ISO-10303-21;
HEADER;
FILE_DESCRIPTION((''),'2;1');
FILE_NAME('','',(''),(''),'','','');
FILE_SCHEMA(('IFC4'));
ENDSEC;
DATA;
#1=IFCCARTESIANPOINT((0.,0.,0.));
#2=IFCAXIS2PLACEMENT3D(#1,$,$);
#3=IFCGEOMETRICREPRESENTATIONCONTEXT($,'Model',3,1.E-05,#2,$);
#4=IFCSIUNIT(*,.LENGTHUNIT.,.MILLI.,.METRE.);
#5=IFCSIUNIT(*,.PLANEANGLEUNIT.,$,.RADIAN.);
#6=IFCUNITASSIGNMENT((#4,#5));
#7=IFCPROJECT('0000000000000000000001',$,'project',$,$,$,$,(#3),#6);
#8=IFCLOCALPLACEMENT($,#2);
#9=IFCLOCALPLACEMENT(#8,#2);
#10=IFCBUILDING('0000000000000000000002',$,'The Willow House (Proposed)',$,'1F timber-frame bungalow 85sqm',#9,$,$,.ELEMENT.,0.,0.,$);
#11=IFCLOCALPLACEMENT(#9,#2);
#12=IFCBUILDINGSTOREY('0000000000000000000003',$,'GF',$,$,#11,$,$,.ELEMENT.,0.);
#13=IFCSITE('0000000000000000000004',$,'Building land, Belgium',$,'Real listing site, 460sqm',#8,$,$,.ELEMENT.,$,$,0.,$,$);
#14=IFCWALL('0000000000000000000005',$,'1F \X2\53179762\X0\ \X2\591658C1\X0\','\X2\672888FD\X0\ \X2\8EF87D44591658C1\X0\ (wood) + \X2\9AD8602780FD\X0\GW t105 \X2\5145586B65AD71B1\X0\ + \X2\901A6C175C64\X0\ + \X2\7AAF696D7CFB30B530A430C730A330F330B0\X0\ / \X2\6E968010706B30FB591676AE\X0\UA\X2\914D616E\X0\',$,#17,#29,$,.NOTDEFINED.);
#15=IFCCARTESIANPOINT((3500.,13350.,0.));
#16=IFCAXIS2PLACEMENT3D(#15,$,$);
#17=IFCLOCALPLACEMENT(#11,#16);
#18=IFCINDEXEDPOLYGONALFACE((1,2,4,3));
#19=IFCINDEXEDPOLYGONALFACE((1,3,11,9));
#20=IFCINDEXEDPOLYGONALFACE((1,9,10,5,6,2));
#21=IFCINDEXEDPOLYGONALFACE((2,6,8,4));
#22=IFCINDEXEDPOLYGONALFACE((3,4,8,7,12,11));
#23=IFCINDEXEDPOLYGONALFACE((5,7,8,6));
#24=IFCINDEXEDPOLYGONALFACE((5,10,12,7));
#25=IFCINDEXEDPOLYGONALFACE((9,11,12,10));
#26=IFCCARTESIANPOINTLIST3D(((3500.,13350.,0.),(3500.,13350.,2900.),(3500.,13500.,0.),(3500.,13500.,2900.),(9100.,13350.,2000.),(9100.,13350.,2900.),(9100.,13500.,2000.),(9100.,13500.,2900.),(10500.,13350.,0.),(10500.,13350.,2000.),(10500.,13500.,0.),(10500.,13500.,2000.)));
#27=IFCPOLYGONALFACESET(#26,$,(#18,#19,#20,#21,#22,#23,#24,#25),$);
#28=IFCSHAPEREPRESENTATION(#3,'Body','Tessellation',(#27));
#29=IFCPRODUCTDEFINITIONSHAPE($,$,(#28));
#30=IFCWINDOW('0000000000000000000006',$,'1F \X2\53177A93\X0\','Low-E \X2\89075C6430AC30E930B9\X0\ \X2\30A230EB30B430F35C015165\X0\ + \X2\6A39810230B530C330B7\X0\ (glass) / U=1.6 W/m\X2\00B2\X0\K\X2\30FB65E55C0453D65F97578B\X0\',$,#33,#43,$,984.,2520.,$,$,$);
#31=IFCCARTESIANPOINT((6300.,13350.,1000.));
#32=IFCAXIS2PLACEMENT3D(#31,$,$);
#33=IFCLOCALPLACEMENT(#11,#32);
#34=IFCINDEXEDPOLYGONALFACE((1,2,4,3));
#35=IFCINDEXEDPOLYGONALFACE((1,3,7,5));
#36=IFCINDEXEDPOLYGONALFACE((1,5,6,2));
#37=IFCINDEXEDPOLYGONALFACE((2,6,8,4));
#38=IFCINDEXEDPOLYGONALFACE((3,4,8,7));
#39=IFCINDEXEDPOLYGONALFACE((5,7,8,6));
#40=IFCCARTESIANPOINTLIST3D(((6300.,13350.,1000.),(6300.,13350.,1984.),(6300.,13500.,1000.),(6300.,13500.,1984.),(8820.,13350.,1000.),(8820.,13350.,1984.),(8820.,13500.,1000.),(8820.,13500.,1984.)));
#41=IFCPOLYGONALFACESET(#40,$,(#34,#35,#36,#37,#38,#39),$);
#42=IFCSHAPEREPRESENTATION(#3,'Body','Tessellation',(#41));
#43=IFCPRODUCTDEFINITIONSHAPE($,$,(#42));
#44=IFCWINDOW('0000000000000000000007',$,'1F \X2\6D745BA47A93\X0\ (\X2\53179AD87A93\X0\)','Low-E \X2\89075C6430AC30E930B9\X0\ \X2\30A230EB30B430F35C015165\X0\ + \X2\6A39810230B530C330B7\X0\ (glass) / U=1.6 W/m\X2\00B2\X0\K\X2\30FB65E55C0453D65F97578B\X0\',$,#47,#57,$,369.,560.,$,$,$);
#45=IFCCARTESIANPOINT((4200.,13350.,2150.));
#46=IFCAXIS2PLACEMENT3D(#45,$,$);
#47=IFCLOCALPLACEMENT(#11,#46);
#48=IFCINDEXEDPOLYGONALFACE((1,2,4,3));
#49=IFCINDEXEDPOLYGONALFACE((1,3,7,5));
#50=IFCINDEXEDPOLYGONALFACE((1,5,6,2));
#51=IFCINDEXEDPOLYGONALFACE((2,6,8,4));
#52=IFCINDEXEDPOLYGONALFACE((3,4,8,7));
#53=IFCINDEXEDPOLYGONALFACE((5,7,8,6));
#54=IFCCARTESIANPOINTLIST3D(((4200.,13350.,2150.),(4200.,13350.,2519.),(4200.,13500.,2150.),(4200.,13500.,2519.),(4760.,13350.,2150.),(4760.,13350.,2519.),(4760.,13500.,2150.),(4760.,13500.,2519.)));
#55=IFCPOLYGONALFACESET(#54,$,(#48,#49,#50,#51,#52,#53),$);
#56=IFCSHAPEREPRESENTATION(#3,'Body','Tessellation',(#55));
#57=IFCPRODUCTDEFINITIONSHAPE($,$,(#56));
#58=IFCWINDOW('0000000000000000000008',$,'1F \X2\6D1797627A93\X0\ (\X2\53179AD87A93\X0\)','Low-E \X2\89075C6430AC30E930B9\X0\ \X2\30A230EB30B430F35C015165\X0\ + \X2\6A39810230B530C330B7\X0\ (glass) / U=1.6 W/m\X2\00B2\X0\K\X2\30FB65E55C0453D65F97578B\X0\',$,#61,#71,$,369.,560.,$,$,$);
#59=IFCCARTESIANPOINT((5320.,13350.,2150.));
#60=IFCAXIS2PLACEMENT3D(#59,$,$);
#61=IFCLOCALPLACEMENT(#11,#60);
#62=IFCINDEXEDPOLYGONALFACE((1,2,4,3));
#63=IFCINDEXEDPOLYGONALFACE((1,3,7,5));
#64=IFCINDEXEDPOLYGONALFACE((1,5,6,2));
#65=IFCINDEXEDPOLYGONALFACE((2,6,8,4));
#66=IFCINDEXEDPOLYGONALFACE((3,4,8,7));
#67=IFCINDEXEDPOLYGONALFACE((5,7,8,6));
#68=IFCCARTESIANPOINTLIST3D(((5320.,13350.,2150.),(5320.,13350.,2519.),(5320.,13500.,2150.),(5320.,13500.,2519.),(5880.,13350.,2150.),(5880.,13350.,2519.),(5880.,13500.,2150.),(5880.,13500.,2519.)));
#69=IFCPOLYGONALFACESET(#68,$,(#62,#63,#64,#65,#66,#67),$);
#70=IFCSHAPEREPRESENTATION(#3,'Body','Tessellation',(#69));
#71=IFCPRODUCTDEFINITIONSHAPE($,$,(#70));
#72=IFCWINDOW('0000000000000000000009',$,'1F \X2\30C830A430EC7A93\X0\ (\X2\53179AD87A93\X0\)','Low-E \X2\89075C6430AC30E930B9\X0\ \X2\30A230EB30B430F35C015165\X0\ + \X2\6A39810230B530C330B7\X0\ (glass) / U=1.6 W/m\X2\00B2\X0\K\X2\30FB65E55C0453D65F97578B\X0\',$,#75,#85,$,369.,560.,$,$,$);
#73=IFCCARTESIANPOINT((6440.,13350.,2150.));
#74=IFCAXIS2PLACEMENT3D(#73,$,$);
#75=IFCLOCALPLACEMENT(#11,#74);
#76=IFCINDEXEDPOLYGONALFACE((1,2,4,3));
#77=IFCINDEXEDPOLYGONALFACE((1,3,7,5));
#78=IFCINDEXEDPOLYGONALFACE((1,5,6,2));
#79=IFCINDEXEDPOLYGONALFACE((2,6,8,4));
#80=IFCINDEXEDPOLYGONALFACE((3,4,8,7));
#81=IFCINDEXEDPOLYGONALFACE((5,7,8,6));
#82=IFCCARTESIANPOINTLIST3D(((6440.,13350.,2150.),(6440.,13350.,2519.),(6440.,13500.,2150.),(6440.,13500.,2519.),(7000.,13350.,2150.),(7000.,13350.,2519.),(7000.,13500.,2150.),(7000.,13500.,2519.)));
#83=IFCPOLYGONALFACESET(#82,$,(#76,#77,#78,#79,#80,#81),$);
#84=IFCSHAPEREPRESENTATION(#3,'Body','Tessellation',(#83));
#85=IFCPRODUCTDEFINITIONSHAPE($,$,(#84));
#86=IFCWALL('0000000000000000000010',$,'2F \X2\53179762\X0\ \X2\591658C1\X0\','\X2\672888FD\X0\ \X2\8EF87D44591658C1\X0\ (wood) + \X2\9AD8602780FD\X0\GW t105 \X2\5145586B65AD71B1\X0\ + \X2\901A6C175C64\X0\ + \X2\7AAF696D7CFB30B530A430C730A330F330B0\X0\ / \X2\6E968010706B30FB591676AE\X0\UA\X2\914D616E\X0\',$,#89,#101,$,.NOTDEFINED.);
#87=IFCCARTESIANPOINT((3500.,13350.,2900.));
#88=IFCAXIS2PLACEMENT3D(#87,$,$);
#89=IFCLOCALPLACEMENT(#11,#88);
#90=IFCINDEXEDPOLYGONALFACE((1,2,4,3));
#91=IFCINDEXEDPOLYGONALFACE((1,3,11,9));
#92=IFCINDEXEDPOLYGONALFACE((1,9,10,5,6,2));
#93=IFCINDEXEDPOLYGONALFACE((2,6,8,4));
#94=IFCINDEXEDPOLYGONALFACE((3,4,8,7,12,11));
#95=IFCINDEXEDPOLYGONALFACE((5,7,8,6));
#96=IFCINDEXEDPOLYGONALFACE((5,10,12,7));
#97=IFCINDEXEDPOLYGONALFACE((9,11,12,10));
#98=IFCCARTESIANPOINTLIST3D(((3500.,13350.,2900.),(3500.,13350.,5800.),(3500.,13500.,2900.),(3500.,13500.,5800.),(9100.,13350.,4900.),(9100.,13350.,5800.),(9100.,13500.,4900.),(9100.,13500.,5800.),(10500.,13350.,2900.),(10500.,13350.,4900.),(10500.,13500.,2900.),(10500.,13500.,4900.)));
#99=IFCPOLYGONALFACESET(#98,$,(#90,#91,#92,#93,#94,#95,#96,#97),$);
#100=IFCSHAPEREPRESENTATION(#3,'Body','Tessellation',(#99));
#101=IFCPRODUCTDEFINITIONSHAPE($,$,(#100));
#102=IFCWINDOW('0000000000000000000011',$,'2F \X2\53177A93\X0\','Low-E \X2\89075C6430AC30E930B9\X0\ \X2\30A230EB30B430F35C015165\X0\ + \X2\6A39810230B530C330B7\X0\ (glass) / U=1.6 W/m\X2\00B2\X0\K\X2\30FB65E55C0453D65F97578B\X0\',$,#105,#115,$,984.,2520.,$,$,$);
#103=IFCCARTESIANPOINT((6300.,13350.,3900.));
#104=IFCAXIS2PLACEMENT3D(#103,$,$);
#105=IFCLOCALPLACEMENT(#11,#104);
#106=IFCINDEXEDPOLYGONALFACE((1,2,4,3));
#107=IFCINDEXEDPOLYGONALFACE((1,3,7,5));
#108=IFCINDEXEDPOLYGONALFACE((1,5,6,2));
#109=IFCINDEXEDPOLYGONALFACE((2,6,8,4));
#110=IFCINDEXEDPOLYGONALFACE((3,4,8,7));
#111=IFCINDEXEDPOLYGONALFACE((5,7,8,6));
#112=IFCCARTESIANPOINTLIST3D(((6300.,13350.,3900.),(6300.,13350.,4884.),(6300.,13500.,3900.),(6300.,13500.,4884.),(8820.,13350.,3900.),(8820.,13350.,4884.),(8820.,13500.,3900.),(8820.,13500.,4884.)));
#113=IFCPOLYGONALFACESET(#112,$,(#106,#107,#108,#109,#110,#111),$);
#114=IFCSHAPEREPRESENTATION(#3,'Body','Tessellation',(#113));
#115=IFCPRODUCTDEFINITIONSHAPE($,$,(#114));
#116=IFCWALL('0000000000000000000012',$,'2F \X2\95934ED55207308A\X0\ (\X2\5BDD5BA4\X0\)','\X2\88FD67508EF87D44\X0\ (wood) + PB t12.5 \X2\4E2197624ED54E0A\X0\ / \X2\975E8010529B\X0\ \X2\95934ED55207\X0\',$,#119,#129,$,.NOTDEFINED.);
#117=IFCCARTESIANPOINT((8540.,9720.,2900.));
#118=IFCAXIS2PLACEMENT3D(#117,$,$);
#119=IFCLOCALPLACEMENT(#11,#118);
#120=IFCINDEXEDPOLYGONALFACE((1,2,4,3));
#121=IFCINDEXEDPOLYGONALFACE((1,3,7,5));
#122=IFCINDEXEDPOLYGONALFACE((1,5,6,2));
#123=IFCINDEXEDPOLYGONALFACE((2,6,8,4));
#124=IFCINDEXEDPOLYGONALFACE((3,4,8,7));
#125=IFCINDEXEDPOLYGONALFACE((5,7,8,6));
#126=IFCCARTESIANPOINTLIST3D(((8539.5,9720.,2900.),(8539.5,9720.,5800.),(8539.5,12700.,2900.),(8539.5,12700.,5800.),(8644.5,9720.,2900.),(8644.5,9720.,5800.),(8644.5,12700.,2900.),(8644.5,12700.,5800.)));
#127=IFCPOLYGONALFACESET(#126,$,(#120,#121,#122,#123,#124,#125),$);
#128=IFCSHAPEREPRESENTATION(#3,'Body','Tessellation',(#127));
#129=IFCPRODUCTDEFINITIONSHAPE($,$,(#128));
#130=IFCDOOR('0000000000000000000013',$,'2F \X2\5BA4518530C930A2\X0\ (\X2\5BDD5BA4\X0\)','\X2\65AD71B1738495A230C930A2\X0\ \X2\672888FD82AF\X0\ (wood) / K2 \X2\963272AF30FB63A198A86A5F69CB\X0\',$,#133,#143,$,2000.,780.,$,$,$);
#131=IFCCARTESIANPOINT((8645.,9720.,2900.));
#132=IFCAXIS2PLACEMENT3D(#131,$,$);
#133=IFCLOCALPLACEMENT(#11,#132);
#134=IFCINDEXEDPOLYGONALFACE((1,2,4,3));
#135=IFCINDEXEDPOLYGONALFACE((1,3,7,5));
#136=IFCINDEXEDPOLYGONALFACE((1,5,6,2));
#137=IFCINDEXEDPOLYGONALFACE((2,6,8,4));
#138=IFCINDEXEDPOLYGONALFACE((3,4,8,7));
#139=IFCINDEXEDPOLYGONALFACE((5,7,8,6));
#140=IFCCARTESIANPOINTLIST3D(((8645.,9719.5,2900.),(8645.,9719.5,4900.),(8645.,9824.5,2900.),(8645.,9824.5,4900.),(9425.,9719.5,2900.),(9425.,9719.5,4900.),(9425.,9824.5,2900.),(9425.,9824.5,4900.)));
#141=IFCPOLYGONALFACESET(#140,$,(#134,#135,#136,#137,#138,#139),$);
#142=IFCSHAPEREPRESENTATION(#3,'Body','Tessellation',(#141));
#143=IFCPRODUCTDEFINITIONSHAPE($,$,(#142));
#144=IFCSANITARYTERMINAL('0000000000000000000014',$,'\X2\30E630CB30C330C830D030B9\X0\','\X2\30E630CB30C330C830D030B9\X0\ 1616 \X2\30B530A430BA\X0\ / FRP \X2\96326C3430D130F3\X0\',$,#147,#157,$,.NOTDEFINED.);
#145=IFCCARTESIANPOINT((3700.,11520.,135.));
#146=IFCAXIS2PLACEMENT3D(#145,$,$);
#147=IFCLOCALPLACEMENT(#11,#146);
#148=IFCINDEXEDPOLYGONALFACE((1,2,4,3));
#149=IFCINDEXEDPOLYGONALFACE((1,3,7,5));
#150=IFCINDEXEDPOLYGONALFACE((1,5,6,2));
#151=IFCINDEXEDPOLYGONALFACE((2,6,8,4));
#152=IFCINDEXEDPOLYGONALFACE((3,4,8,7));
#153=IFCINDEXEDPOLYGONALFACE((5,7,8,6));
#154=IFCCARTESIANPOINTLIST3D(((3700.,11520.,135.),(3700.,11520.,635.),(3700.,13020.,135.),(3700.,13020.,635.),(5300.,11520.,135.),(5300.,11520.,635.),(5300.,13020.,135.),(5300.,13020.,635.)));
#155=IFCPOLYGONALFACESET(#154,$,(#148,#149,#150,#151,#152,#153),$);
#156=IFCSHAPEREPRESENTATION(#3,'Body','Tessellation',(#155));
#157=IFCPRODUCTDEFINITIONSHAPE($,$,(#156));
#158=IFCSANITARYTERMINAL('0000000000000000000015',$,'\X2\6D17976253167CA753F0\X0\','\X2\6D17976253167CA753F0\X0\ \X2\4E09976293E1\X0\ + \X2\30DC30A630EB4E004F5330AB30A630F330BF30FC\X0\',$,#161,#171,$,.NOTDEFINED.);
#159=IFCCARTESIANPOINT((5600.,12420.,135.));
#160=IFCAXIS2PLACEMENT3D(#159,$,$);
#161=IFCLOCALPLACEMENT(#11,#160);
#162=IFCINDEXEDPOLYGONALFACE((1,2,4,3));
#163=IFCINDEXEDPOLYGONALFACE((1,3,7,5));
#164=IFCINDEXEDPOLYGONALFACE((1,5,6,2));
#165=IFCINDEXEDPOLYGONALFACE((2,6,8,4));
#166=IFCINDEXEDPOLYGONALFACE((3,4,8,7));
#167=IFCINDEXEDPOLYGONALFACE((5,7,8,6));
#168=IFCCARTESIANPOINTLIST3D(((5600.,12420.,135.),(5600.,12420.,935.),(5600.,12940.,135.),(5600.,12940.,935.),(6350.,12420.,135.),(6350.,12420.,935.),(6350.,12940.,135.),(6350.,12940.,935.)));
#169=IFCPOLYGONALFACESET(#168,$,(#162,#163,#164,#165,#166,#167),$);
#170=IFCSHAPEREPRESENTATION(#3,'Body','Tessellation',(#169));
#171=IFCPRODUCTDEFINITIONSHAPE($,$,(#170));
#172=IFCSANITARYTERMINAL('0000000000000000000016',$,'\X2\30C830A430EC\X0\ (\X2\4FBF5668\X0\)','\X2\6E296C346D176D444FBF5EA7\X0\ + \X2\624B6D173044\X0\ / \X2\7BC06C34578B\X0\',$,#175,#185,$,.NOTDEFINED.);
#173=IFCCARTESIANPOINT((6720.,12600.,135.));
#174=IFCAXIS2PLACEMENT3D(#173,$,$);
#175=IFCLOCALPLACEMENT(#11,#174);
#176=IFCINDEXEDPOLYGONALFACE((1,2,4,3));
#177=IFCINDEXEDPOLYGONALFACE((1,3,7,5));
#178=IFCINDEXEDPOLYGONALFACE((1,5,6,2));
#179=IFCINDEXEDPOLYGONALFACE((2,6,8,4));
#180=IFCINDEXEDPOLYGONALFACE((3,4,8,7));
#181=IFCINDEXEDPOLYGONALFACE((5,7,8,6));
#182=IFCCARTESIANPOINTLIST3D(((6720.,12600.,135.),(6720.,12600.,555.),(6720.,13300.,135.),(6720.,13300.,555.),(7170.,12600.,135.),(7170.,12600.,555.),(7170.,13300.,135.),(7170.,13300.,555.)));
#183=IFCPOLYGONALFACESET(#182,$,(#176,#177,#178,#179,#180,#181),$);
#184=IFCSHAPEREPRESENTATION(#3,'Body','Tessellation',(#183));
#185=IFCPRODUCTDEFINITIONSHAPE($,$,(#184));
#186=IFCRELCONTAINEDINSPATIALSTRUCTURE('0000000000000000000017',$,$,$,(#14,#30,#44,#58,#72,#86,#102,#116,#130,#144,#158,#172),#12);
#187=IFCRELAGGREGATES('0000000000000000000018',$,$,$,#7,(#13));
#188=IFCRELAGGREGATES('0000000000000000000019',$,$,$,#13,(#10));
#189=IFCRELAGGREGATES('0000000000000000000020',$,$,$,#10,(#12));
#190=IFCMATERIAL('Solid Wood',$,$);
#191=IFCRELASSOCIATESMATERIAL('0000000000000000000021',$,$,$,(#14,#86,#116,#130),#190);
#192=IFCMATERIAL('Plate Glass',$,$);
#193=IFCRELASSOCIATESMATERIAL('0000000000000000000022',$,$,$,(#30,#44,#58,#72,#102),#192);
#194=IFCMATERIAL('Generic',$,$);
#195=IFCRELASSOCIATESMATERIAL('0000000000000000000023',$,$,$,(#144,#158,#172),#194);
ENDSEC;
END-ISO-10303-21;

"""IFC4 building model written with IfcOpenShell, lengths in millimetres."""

from ifc_helpers import new_model, si_unit, frame, frame_2d, origin, place, context, project, spatial, rectangle, extrude, material, element, fill, save


model = new_model("IFC4")

# Units and contexts
model_context = context("Model", 3, precision=1e-05, world=origin())
ifc_project = project(units=[si_unit("LENGTHUNIT", "METRE", prefix="MILLI"), si_unit("PLANEANGLEUNIT", "RADIAN")], contexts=[model_context])

# Site, building, storey
site_placement = place(None, origin())
site = spatial("IfcSite", under=ifc_project, at=site_placement, Name="Building land, Belgium", ObjectType="Real listing site, 460sqm", CompositionType="ELEMENT", RefElevation=0.0)
building_placement = place(site_placement, origin())
building = spatial("IfcBuilding", under=site, at=building_placement, Name="The Willow House (Proposed)", ObjectType="1F timber-frame bungalow 85sqm", CompositionType="ELEMENT", ElevationOfRefHeight=0.0, ElevationOfTerrain=0.0)
storey_placement = place(building_placement, origin())
storey = spatial("IfcBuildingStorey", under=building, at=storey_placement, Name="GF", CompositionType="ELEMENT", Elevation=0.0)

# Wall, openings, windows
ifc_material_1 = material(Name="Solid Wood")
wall_1_placement = place(storey_placement, frame((3500.0, 13350.0, 0.0)))
wall_1 = element("IfcWall", 1, at=wall_1_placement, inside=storey, material=ifc_material_1, Name="1F 北面 外壁", Description="木製 軸組外壁 (wood) + 高性能GW t105 充填断熱 + 通気層 + 窯業系サイディング / 準耐火・外皮UA配慮", PredefinedType="NOTDEFINED", context=model_context, shape_type="SweptSolid", body=[
    extrude(rectangle(XDim=7000.0, YDim=150.0, at=frame_2d((3500.0, 75.0))), frame((3500.0, 13350.0, 0.0)), (0.0, 0.0, 1.0), 2900.0),
])
opening_1_placement = place(storey_placement, frame((6300.0, 13350.0, 1000.0)))
opening_1 = element("IfcOpeningElement", 2, at=opening_1_placement, cuts=wall_1, PredefinedType="NOTDEFINED", context=model_context, shape_type="SweptSolid", body=[
    extrude(rectangle(XDim=2520.0, YDim=150.0, at=frame_2d((1260.0, 75.0))), frame((6300.0, 13350.0, 1000.0)), (0.0, 0.0, 1.0), 984.0),
])
opening_2_placement = place(storey_placement, frame((4200.0, 13350.0, 2150.0)))
opening_2 = element("IfcOpeningElement", 3, at=opening_2_placement, cuts=wall_1, PredefinedType="NOTDEFINED", context=model_context, shape_type="SweptSolid", body=[
    extrude(rectangle(XDim=560.0, YDim=150.0, at=frame_2d((280.0, 75.0))), frame((4200.0, 13350.0, 2150.0)), (0.0, 0.0, 1.0), 369.0),
])
opening_3_placement = place(storey_placement, frame((5320.0, 13350.0, 2150.0)))
opening_3 = element("IfcOpeningElement", 4, at=opening_3_placement, cuts=wall_1, PredefinedType="NOTDEFINED", context=model_context, shape_type="SweptSolid", body=[
    extrude(rectangle(XDim=560.0, YDim=150.0, at=frame_2d((280.0, 75.0))), frame((5320.0, 13350.0, 2150.0)), (0.0, 0.0, 1.0), 369.0),
])
opening_4_placement = place(storey_placement, frame((6440.0, 13350.0, 2150.0)))
opening_4 = element("IfcOpeningElement", 5, at=opening_4_placement, cuts=wall_1, PredefinedType="NOTDEFINED", context=model_context, shape_type="SweptSolid", body=[
    extrude(rectangle(XDim=560.0, YDim=150.0, at=frame_2d((280.0, 75.0))), frame((6440.0, 13350.0, 2150.0)), (0.0, 0.0, 1.0), 369.0),
])
ifc_material_2 = material(Name="Plate Glass")
window_1_placement = place(storey_placement, frame((6300.0, 13350.0, 1000.0)))
window_1 = element("IfcWindow", 6, at=window_1_placement, inside=storey, material=ifc_material_2, Name="1F 北窓", Description="Low-E 複層ガラス アルゴン封入 + 樹脂サッシ (glass) / U=1.6 W/m²K・日射取得型", OverallHeight=984.0, OverallWidth=2520.0, context=model_context, shape_type="SweptSolid", body=[
    extrude(rectangle(XDim=2520.0, YDim=150.0, at=frame_2d((1260.0, 75.0))), frame((6300.0, 13350.0, 1000.0)), (0.0, 0.0, 1.0), 984.0),
])
fill(opening_1, window_1)
window_2_placement = place(storey_placement, frame((4200.0, 13350.0, 2150.0)))
window_2 = element("IfcWindow", 7, at=window_2_placement, inside=storey, material=ifc_material_2, Name="1F 浴室窓 (北高窓)", Description="Low-E 複層ガラス アルゴン封入 + 樹脂サッシ (glass) / U=1.6 W/m²K・日射取得型", OverallHeight=369.0, OverallWidth=560.0, context=model_context, shape_type="SweptSolid", body=[
    extrude(rectangle(XDim=560.0, YDim=150.0, at=frame_2d((280.0, 75.0))), frame((4200.0, 13350.0, 2150.0)), (0.0, 0.0, 1.0), 369.0),
])
fill(opening_2, window_2)
window_3_placement = place(storey_placement, frame((5320.0, 13350.0, 2150.0)))
window_3 = element("IfcWindow", 8, at=window_3_placement, inside=storey, material=ifc_material_2, Name="1F 洗面窓 (北高窓)", Description="Low-E 複層ガラス アルゴン封入 + 樹脂サッシ (glass) / U=1.6 W/m²K・日射取得型", OverallHeight=369.0, OverallWidth=560.0, context=model_context, shape_type="SweptSolid", body=[
    extrude(rectangle(XDim=560.0, YDim=150.0, at=frame_2d((280.0, 75.0))), frame((5320.0, 13350.0, 2150.0)), (0.0, 0.0, 1.0), 369.0),
])
fill(opening_3, window_3)
window_4_placement = place(storey_placement, frame((6440.0, 13350.0, 2150.0)))
window_4 = element("IfcWindow", 9, at=window_4_placement, inside=storey, material=ifc_material_2, Name="1F トイレ窓 (北高窓)", Description="Low-E 複層ガラス アルゴン封入 + 樹脂サッシ (glass) / U=1.6 W/m²K・日射取得型", OverallHeight=369.0, OverallWidth=560.0, context=model_context, shape_type="SweptSolid", body=[
    extrude(rectangle(XDim=560.0, YDim=150.0, at=frame_2d((280.0, 75.0))), frame((6440.0, 13350.0, 2150.0)), (0.0, 0.0, 1.0), 369.0),
])
fill(opening_4, window_4)

# Wall, opening, window
wall_2_placement = place(storey_placement, frame((3500.0, 13350.0, 2900.0)))
wall_2 = element("IfcWall", 10, at=wall_2_placement, inside=storey, material=ifc_material_1, Name="2F 北面 外壁", Description="木製 軸組外壁 (wood) + 高性能GW t105 充填断熱 + 通気層 + 窯業系サイディング / 準耐火・外皮UA配慮", PredefinedType="NOTDEFINED", context=model_context, shape_type="SweptSolid", body=[
    extrude(rectangle(XDim=7000.0, YDim=150.0, at=frame_2d((3500.0, 75.0))), frame((3500.0, 13350.0, 2900.0)), (0.0, 0.0, 1.0), 2900.0),
])
opening_5_placement = place(storey_placement, frame((6300.0, 13350.0, 3900.0)))
opening_5 = element("IfcOpeningElement", 11, at=opening_5_placement, cuts=wall_2, PredefinedType="NOTDEFINED", context=model_context, shape_type="SweptSolid", body=[
    extrude(rectangle(XDim=2520.0, YDim=150.0, at=frame_2d((1260.0, 75.0))), frame((6300.0, 13350.0, 3900.0)), (0.0, 0.0, 1.0), 984.0),
])
window_5_placement = place(storey_placement, frame((6300.0, 13350.0, 3900.0)))
window_5 = element("IfcWindow", 12, at=window_5_placement, inside=storey, material=ifc_material_2, Name="2F 北窓", Description="Low-E 複層ガラス アルゴン封入 + 樹脂サッシ (glass) / U=1.6 W/m²K・日射取得型", OverallHeight=984.0, OverallWidth=2520.0, context=model_context, shape_type="SweptSolid", body=[
    extrude(rectangle(XDim=2520.0, YDim=150.0, at=frame_2d((1260.0, 75.0))), frame((6300.0, 13350.0, 3900.0)), (0.0, 0.0, 1.0), 984.0),
])
fill(opening_5, window_5)

# Wall
wall_3_placement = place(storey_placement, frame((8540.0, 9720.0, 2900.0)))
element("IfcWall", 13, at=wall_3_placement, inside=storey, material=ifc_material_1, Name="2F 間仕切り (寝室)", Description="製材軸組 (wood) + PB t12.5 両面仕上 / 非耐力 間仕切", PredefinedType="NOTDEFINED", context=model_context, shape_type="SweptSolid", body=[
    extrude(rectangle(XDim=105.0, YDim=2980.0, at=frame_2d((52.0, 1490.0))), frame((8540.0, 9720.0, 2900.0)), (0.0, 0.0, 1.0), 2900.0),
])

# Door
door_1_placement = place(storey_placement, frame((8645.0, 9720.0, 2900.0)))
element("IfcDoor", 14, at=door_1_placement, inside=storey, material=ifc_material_1, Name="2F 室内ドア (寝室)", Description="断熱玄関ドア 木製芯 (wood) / K2 防犯・採風機構", OverallHeight=2000.0, OverallWidth=780.0, context=model_context, shape_type="SweptSolid", body=[
    extrude(rectangle(XDim=780.0, YDim=105.0, at=frame_2d((390.0, 52.0))), frame((8645.0, 9720.0, 2900.0)), (0.0, 0.0, 1.0), 2000.0),
])

# Sanitary terminals
ifc_material_3 = material(Name="Generic")
sanitary_terminal_1_placement = place(storey_placement, frame((3700.0, 11520.0, 135.0)))
element("IfcSanitaryTerminal", 15, at=sanitary_terminal_1_placement, inside=storey, material=ifc_material_3, Name="ユニットバス", Description="ユニットバス 1616 サイズ / FRP 防水パン", PredefinedType="NOTDEFINED", context=model_context, shape_type="SweptSolid", body=[
    extrude(rectangle(XDim=1600.0, YDim=1500.0, at=frame_2d((800.0, 750.0))), frame((3700.0, 11520.0, 135.0)), (0.0, 0.0, 1.0), 500.0),
])
sanitary_terminal_2_placement = place(storey_placement, frame((5600.0, 12420.0, 135.0)))
element("IfcSanitaryTerminal", 16, at=sanitary_terminal_2_placement, inside=storey, material=ifc_material_3, Name="洗面化粧台", Description="洗面化粧台 三面鏡 + ボウル一体カウンター", PredefinedType="NOTDEFINED", context=model_context, shape_type="SweptSolid", body=[
    extrude(rectangle(XDim=750.0, YDim=520.0, at=frame_2d((375.0, 260.0))), frame((5600.0, 12420.0, 135.0)), (0.0, 0.0, 1.0), 800.0),
])
sanitary_terminal_3_placement = place(storey_placement, frame((6720.0, 12600.0, 135.0)))
element("IfcSanitaryTerminal", 17, at=sanitary_terminal_3_placement, inside=storey, material=ifc_material_3, Name="トイレ (便器)", Description="温水洗浄便座 + 手洗い / 節水型", PredefinedType="NOTDEFINED", context=model_context, shape_type="SweptSolid", body=[
    extrude(rectangle(XDim=450.0, YDim=700.0, at=frame_2d((225.0, 350.0))), frame((6720.0, 12600.0, 135.0)), (0.0, 0.0, 1.0), 420.0),
])

save(model, "model.ifc")
